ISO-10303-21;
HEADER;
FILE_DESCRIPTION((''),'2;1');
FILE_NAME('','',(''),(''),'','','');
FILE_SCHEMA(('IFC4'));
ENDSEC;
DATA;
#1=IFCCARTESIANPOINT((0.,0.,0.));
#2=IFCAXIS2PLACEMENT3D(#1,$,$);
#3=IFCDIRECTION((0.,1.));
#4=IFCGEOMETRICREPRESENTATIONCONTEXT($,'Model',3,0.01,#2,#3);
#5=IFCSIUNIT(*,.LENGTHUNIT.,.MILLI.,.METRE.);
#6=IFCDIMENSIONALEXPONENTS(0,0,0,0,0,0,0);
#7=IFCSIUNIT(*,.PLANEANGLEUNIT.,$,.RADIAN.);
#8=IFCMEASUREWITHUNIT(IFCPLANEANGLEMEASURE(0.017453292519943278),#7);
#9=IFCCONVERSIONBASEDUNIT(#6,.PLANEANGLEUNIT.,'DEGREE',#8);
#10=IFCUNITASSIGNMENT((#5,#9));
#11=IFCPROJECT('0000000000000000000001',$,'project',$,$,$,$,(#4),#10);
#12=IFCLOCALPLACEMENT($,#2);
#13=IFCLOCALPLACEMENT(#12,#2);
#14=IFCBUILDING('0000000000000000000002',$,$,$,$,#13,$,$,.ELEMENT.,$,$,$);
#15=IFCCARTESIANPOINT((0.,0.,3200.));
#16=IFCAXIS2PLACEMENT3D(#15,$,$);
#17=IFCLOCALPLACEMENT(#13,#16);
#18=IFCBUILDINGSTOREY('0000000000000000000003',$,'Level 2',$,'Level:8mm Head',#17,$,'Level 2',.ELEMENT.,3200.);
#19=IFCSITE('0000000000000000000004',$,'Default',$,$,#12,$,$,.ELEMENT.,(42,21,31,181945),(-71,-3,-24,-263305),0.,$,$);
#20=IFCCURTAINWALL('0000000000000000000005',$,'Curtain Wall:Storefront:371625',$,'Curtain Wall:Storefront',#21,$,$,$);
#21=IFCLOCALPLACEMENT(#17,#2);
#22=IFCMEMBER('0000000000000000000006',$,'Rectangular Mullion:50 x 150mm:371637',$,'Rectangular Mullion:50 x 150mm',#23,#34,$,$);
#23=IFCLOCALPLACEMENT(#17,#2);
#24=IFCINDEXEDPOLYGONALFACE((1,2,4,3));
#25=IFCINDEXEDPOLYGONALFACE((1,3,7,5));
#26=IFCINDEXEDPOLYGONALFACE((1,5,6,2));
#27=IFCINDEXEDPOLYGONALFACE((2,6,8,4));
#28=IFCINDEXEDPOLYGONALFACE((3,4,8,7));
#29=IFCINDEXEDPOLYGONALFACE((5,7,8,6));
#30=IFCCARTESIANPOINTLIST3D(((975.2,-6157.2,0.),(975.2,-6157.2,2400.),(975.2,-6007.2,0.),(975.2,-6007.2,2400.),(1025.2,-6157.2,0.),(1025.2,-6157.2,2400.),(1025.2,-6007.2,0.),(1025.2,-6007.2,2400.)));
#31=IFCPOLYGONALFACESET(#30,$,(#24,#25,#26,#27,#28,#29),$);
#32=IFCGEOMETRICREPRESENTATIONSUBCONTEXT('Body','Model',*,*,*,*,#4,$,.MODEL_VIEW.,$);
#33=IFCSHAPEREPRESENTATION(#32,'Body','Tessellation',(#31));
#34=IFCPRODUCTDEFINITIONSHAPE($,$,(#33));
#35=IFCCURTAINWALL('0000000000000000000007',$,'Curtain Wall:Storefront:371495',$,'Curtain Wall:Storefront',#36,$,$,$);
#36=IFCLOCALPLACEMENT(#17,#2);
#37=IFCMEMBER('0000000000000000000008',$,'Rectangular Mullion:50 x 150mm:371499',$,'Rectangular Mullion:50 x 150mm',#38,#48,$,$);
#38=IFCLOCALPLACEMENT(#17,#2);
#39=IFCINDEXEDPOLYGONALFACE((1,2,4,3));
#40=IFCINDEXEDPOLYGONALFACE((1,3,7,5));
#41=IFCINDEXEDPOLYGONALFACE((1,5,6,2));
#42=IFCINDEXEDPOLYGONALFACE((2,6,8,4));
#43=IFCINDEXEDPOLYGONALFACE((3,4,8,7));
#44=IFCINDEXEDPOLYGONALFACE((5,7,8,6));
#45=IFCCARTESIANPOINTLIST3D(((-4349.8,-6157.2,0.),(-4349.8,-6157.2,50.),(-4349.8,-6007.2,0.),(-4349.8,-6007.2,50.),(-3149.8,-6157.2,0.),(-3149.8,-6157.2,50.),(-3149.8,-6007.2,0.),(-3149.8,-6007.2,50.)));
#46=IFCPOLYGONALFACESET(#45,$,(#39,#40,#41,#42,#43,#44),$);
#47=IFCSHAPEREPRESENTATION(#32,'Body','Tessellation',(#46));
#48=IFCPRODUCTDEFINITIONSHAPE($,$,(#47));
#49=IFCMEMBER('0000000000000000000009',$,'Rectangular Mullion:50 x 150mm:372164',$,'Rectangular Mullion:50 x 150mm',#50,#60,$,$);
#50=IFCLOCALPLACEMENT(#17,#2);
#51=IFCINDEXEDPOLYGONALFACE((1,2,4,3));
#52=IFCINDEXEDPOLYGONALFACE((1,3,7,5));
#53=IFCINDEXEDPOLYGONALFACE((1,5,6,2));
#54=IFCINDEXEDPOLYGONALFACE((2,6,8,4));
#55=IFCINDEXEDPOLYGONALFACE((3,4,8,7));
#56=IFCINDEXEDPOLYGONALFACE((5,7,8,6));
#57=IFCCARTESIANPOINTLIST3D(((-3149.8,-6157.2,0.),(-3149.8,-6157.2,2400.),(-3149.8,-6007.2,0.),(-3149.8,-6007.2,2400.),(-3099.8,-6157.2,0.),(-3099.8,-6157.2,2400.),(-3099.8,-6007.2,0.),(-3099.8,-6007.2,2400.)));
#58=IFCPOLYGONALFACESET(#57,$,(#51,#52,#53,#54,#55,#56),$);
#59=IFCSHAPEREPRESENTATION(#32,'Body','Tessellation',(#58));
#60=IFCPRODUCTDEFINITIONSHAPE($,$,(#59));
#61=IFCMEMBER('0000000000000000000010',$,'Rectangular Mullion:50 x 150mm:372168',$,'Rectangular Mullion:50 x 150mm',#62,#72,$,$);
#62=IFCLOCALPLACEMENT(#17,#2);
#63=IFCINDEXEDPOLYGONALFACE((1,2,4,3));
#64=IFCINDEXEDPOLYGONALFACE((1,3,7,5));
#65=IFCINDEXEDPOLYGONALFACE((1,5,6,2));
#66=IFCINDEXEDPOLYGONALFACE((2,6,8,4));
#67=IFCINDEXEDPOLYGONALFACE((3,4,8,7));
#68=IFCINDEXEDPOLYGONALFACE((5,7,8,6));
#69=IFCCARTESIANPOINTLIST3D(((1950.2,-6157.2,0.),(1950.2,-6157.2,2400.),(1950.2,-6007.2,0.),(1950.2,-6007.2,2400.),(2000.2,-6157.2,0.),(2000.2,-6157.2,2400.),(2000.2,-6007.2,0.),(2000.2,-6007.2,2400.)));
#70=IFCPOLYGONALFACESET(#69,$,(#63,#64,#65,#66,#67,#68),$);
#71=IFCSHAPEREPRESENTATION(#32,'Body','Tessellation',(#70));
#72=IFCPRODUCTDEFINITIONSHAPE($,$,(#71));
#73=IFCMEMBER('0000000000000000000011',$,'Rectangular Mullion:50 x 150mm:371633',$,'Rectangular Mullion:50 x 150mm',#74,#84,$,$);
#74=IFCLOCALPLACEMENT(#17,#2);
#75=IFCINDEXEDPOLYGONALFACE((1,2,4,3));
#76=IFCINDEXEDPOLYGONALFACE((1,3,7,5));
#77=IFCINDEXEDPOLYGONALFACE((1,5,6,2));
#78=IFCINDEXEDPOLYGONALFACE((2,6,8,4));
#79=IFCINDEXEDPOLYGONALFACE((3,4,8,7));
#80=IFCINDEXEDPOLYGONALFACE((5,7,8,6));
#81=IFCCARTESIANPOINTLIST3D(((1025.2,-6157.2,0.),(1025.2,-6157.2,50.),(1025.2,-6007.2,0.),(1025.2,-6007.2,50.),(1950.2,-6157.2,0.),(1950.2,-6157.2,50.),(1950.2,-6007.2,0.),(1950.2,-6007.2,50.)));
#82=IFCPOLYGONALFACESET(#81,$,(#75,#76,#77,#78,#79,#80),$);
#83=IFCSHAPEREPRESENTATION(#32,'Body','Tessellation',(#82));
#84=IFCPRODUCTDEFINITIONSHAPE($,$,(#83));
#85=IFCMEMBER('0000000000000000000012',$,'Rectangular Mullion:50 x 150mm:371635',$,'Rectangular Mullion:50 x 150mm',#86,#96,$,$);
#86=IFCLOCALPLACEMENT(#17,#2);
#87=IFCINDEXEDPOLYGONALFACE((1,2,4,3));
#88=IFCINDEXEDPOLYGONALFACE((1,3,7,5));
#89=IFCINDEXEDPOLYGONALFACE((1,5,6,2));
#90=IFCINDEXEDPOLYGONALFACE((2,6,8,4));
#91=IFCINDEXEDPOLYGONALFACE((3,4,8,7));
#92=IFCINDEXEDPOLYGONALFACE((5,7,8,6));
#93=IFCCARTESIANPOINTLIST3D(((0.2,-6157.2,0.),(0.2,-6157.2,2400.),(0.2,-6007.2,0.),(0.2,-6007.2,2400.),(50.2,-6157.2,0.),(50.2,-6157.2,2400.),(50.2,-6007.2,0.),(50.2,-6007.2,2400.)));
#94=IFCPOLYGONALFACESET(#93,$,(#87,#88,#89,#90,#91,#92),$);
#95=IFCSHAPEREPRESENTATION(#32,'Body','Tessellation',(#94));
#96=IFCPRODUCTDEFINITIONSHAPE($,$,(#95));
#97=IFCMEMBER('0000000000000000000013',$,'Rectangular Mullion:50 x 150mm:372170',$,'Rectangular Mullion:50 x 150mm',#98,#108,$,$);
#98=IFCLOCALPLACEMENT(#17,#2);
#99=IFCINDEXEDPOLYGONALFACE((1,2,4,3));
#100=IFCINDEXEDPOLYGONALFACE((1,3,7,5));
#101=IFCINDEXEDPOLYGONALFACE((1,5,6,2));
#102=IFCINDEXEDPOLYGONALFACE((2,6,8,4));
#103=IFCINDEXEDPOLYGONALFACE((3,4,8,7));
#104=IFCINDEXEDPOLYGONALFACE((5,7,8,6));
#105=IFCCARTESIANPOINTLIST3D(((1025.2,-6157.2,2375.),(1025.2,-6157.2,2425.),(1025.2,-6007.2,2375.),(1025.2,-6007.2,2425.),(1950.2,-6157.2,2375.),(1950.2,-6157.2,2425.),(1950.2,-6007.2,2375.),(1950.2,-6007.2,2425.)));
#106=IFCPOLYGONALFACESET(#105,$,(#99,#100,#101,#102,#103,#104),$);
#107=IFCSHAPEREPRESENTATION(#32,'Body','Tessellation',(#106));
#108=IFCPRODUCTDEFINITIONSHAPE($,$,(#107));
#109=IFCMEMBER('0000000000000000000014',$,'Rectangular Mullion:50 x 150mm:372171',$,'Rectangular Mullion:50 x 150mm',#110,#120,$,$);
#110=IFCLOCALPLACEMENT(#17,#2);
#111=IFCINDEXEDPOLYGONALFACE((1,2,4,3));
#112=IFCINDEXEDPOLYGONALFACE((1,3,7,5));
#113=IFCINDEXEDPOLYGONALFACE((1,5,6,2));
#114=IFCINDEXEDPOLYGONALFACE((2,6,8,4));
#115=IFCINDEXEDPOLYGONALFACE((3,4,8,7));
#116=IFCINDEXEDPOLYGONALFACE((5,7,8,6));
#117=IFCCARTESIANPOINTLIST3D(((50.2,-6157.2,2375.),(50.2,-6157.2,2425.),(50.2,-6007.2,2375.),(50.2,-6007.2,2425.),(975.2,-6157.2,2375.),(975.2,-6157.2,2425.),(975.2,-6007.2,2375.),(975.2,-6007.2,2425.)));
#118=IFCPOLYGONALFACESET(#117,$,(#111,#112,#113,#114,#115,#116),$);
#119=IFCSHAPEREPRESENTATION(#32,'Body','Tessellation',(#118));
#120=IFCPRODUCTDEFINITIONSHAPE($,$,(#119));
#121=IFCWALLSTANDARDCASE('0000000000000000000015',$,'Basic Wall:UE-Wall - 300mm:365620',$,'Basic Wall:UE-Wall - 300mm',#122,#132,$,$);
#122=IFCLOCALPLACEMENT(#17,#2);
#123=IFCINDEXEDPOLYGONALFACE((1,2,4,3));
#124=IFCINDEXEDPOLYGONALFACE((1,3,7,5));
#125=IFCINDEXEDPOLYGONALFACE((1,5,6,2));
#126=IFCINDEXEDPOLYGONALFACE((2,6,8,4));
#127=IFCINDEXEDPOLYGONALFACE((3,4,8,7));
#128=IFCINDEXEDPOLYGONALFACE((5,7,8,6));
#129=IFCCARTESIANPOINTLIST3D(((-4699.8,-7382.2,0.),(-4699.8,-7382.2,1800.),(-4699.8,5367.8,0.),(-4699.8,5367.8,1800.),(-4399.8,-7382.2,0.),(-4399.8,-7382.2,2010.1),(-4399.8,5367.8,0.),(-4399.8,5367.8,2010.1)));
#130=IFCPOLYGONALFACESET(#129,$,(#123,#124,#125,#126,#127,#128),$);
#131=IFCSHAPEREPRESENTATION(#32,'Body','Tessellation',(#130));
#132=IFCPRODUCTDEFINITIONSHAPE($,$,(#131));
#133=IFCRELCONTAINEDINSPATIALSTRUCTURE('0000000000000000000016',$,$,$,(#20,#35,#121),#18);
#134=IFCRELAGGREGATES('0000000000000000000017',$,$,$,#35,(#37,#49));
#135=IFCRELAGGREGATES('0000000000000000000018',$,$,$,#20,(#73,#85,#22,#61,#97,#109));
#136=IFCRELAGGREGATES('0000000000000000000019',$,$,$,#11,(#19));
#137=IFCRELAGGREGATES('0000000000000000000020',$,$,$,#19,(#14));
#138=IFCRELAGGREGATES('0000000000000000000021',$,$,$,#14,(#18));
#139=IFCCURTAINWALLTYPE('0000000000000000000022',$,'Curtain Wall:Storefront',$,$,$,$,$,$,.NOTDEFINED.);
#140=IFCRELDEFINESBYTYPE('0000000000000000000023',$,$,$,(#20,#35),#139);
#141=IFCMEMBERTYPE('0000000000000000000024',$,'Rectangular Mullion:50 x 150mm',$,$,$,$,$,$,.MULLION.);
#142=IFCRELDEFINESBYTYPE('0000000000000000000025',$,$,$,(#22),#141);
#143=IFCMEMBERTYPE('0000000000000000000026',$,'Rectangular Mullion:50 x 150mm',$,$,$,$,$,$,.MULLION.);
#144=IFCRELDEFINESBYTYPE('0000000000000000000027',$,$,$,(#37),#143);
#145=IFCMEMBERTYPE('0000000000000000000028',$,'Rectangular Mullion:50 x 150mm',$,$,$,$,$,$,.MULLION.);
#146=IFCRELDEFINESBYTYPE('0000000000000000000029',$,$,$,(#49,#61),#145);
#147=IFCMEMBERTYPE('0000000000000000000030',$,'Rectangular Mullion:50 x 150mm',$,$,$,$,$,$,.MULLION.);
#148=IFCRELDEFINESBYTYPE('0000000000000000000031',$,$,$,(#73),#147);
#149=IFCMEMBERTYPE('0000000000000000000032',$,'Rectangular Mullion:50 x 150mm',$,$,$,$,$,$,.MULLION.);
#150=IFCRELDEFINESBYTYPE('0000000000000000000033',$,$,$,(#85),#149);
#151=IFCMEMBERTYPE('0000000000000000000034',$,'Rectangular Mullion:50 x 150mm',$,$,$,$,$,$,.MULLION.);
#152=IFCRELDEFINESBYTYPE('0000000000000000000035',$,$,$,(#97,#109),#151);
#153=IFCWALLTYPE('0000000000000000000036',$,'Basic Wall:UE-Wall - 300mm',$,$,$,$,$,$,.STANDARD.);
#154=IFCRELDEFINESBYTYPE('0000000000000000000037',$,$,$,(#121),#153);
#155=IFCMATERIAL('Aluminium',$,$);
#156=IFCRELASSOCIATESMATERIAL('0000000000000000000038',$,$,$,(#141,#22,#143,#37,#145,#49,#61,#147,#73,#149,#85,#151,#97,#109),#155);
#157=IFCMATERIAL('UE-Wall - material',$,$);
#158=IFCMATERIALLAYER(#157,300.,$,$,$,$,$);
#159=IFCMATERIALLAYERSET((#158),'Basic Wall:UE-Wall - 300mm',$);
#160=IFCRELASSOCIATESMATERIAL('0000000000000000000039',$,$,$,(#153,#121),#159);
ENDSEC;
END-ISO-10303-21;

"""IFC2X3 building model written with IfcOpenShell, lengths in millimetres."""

from ifc_helpers import new_model, entity, si_unit, converted_unit, direction, frame, frame_2d, origin, origin_2d_with_axis, place, context, subcontext, project, spatial, polyline, rectangle, extrude, clip, bounded_halfspace, source, transform, mapped, material, layer, layer_set, layer_usage, type_object, type_shapes, element, aggregate, save


model = new_model("IFC2X3")

# Units and contexts
model_context = context("Model", 3, precision=0.01, world=origin(), true_north=direction((0.0, 1.0)))
body_context = subcontext(model_context, "Body", "Model", "MODEL_VIEW")
ifc_project = project(units=[si_unit("LENGTHUNIT", "METRE", prefix="MILLI"), converted_unit("PLANEANGLEUNIT", "DEGREE", entity("IfcPlaneAngleMeasure", 0.017453292519943278), si_unit("PLANEANGLEUNIT", "RADIAN"), dimensions=[0, 0, 0, 0, 0, 0, 0])], contexts=[model_context])

# Site, building, storey
site_placement = place(None, origin())
site = spatial("IfcSite", under=ifc_project, at=site_placement, Name="Default", CompositionType="ELEMENT", RefLatitude=(42, 21, 31, 181945), RefLongitude=(-71, -3, -24, -263305), RefElevation=0.0)
building_placement = place(site_placement, origin())
building = spatial("IfcBuilding", under=site, at=building_placement, CompositionType="ELEMENT")
storey_placement = place(building_placement, frame((0.0, 0.0, 3200.0)))
storey = spatial("IfcBuildingStorey", under=building, at=storey_placement, Name="Level 2", ObjectType="Level:8mm Head", LongName="Level 2", CompositionType="ELEMENT", Elevation=3200.0)

# Curtain wall, member
curtain_wall_type = type_object("IfcCurtainWallType", Name="Curtain Wall:Storefront", PredefinedType="NOTDEFINED")
curtain_wall_1_placement = place(storey_placement, frame((0.0, 0.0, -3200.0)))
curtain_wall_1 = element("IfcCurtainWall", 1, at=curtain_wall_1_placement, inside=storey, type_object=curtain_wall_type, Name="Curtain Wall:Storefront:371625", ObjectType="Curtain Wall:Storefront")
ifc_material_1 = material(Name="Aluminium")
member_type_1 = type_object("IfcMemberType", Name="Rectangular Mullion:50 x 150mm", PredefinedType="MULLION", material=ifc_material_1)
shared_shape_1 = source(origin(), body_context, "Body", "SweptSolid", [
    extrude(rectangle(XDim=50.0, YDim=150.0, at=origin_2d_with_axis()), frame((0.0, 0.0, -2400.0), z_axis=(0.0, 0.0, 1.0), x_axis=(-1.0, 0.0, 0.0)), (0.0, 0.0, 1.0), 2400.0),
])
type_shapes(member_type_1, [shared_shape_1])
member_1_placement = place(curtain_wall_1_placement, frame((1000.2, -6082.2, 3200.0), z_axis=(0.0, 0.0, -1.0), x_axis=(-1.0, 0.0, 0.0)))
member_1 = element("IfcMember", 2, at=member_1_placement, type_object=member_type_1, material=ifc_material_1, Name="Rectangular Mullion:50 x 150mm:371637", ObjectType="Rectangular Mullion:50 x 150mm", context=body_context, shape_type="MappedRepresentation", body=[
    mapped(shared_shape_1, transform((0.0, 0.0, 0.0), scale=1.0)),
])

# Curtain wall, members
curtain_wall_2_placement = place(storey_placement, frame((0.0, 0.0, -3200.0)))
curtain_wall_2 = element("IfcCurtainWall", 3, at=curtain_wall_2_placement, inside=storey, type_object=curtain_wall_type, Name="Curtain Wall:Storefront:371495", ObjectType="Curtain Wall:Storefront")
member_type_2 = type_object("IfcMemberType", Name="Rectangular Mullion:50 x 150mm", PredefinedType="MULLION", material=ifc_material_1)
shared_shape_2 = source(origin(), body_context, "Body", "SweptSolid", [
    extrude(rectangle(XDim=50.0, YDim=150.0, at=origin_2d_with_axis()), frame((-25.0, 0.0, -1200.0), z_axis=(0.0, 0.0, 1.0), x_axis=(-1.0, 0.0, 0.0)), (0.0, 0.0, 1.0), 1200.0),
])
type_shapes(member_type_2, [shared_shape_2])
member_2_placement = place(curtain_wall_2_placement, frame((-3149.8, -6082.2, 3200.0), z_axis=(1.0, 0.0, 0.0), x_axis=(0.0, 0.0, -1.0)))
member_2 = element("IfcMember", 4, at=member_2_placement, type_object=member_type_2, material=ifc_material_1, Name="Rectangular Mullion:50 x 150mm:371499", ObjectType="Rectangular Mullion:50 x 150mm", context=body_context, shape_type="MappedRepresentation", body=[
    mapped(shared_shape_2, transform((0.0, 0.0, 0.0), scale=1.0)),
])
member_type_3 = type_object("IfcMemberType", Name="Rectangular Mullion:50 x 150mm", PredefinedType="MULLION", material=ifc_material_1)
shared_shape_3 = source(origin(), body_context, "Body", "SweptSolid", [
    extrude(rectangle(XDim=50.0, YDim=150.0, at=origin_2d_with_axis()), frame((-25.0, 0.0, -2400.0), z_axis=(0.0, 0.0, 1.0), x_axis=(-1.0, 0.0, 0.0)), (0.0, 0.0, 1.0), 2400.0),
])
type_shapes(member_type_3, [shared_shape_3])
member_3_placement = place(curtain_wall_2_placement, frame((-3099.8, -6082.2, 5600.0)))
member_3 = element("IfcMember", 5, at=member_3_placement, type_object=member_type_3, material=ifc_material_1, Name="Rectangular Mullion:50 x 150mm:372164", ObjectType="Rectangular Mullion:50 x 150mm", context=body_context, shape_type="MappedRepresentation", body=[
    mapped(shared_shape_3, transform((0.0, 0.0, 0.0), scale=1.0)),
])

# Members
member_4_placement = place(curtain_wall_1_placement, frame((2000.2, -6082.2, 5600.0)))
member_4 = element("IfcMember", 6, at=member_4_placement, type_object=member_type_3, material=ifc_material_1, Name="Rectangular Mullion:50 x 150mm:372168", ObjectType="Rectangular Mullion:50 x 150mm", context=body_context, shape_type="MappedRepresentation", body=[
    mapped(shared_shape_3, transform((0.0, 0.0, 0.0), scale=1.0)),
])
member_type_4 = type_object("IfcMemberType", Name="Rectangular Mullion:50 x 150mm", PredefinedType="MULLION", material=ifc_material_1)
shared_shape_4 = source(origin(), body_context, "Body", "SweptSolid", [
    extrude(rectangle(XDim=50.0, YDim=150.0, at=origin_2d_with_axis()), frame((-25.0, 0.0, -925.0), z_axis=(0.0, 0.0, 1.0), x_axis=(-1.0, 0.0, 0.0)), (0.0, 0.0, 1.0), 925.0),
])
type_shapes(member_type_4, [shared_shape_4])
member_5_placement = place(curtain_wall_1_placement, frame((1950.2, -6082.2, 3200.0), z_axis=(1.0, 0.0, 0.0), x_axis=(0.0, 0.0, -1.0)))
member_5 = element("IfcMember", 7, at=member_5_placement, type_object=member_type_4, material=ifc_material_1, Name="Rectangular Mullion:50 x 150mm:371633", ObjectType="Rectangular Mullion:50 x 150mm", context=body_context, shape_type="MappedRepresentation", body=[
    mapped(shared_shape_4, transform((0.0, 0.0, 0.0), scale=1.0)),
])
member_type_5 = type_object("IfcMemberType", Name="Rectangular Mullion:50 x 150mm", PredefinedType="MULLION", material=ifc_material_1)
shared_shape_5 = source(origin(), body_context, "Body", "SweptSolid", [
    extrude(rectangle(XDim=50.0, YDim=150.0, at=origin_2d_with_axis()), frame((-25.0, 0.0, -2400.0), z_axis=(0.0, 0.0, 1.0), x_axis=(-1.0, 0.0, 0.0)), (0.0, 0.0, 1.0), 2400.0),
])
type_shapes(member_type_5, [shared_shape_5])
member_6_placement = place(curtain_wall_1_placement, frame((0.2, -6082.2, 3200.0), z_axis=(0.0, 0.0, -1.0), x_axis=(-1.0, 0.0, 0.0)))
member_6 = element("IfcMember", 8, at=member_6_placement, type_object=member_type_5, material=ifc_material_1, Name="Rectangular Mullion:50 x 150mm:371635", ObjectType="Rectangular Mullion:50 x 150mm", context=body_context, shape_type="MappedRepresentation", body=[
    mapped(shared_shape_5, transform((0.0, 0.0, 0.0), scale=1.0)),
])
member_type_6 = type_object("IfcMemberType", Name="Rectangular Mullion:50 x 150mm", PredefinedType="MULLION", material=ifc_material_1)
shared_shape_6 = source(origin(), body_context, "Body", "SweptSolid", [
    extrude(rectangle(XDim=50.0, YDim=150.0, at=origin_2d_with_axis()), frame((0.0, 0.0, -925.0), z_axis=(0.0, 0.0, 1.0), x_axis=(-1.0, 0.0, 0.0)), (0.0, 0.0, 1.0), 925.0),
])
type_shapes(member_type_6, [shared_shape_6])
member_7_placement = place(curtain_wall_1_placement, frame((1025.2, -6082.2, 5600.0), z_axis=(-1.0, 0.0, 0.0), x_axis=(0.0, 0.0, 1.0)))
member_7 = element("IfcMember", 9, at=member_7_placement, type_object=member_type_6, material=ifc_material_1, Name="Rectangular Mullion:50 x 150mm:372170", ObjectType="Rectangular Mullion:50 x 150mm", context=body_context, shape_type="MappedRepresentation", body=[
    mapped(shared_shape_6, transform((0.0, 0.0, 0.0), scale=1.0)),
])
member_8_placement = place(curtain_wall_1_placement, frame((50.2, -6082.2, 5600.0), z_axis=(-1.0, 0.0, 0.0), x_axis=(0.0, 0.0, 1.0)))
member_8 = element("IfcMember", 10, at=member_8_placement, type_object=member_type_6, material=ifc_material_1, Name="Rectangular Mullion:50 x 150mm:372171", ObjectType="Rectangular Mullion:50 x 150mm", context=body_context, shape_type="MappedRepresentation", body=[
    mapped(shared_shape_6, transform((0.0, 0.0, 0.0), scale=1.0)),
])

aggregate(curtain_wall_2, [member_2, member_3])

# Wall
ifc_material_2 = material(Name="UE-Wall - material")
ifc_layer_1 = layer(ifc_material_2, 300.0)
ifc_layer_set_1 = layer_set([ifc_layer_1], Name="Basic Wall:UE-Wall - 300mm")
ifc_layer_usage_1 = layer_usage(ifc_layer_set_1, "AXIS2", "NEGATIVE", 150.0)
wall_type_1 = type_object("IfcWallType", Name="Basic Wall:UE-Wall - 300mm", PredefinedType="STANDARD", material=ifc_layer_set_1)
wall_1_placement = place(storey_placement, frame((-4549.8, -7382.2, 0.0), z_axis=(0.0, 0.0, 1.0), x_axis=(0.0, 1.0, 0.0)))
element("IfcWallStandardCase", 11, at=wall_1_placement, inside=storey, type_object=wall_type_1, material=ifc_layer_usage_1, Name="Basic Wall:UE-Wall - 300mm:365620", ObjectType="Basic Wall:UE-Wall - 300mm", context=body_context, shape_type="Clipping", body=[
    clip(extrude(rectangle(XDim=12750.0, YDim=300.0, at=frame_2d((6375.0, 0.0), x_axis=(-1.0, 0.0))), origin(), (0.0, 0.0, 1.0), 2010.1), bounded_halfspace(frame((0.0, -150.0, 2010.1), z_axis=(0.0, 0.573576, 0.819152), x_axis=(-1.0, 0.0, 0.0)), False, frame((0.0, -150.0, 2010.1)), polyline([(0.0, 0.0), (1150.0, 0.0), (1450.0, 0.0), (12750.0, 0.0), (12750.0, 300.0), (0.0, 300.0), (0.0, 0.0)]))),
])

aggregate(curtain_wall_1, [member_5, member_6, member_1, member_4, member_7, member_8])

save(model, "model.ifc")
